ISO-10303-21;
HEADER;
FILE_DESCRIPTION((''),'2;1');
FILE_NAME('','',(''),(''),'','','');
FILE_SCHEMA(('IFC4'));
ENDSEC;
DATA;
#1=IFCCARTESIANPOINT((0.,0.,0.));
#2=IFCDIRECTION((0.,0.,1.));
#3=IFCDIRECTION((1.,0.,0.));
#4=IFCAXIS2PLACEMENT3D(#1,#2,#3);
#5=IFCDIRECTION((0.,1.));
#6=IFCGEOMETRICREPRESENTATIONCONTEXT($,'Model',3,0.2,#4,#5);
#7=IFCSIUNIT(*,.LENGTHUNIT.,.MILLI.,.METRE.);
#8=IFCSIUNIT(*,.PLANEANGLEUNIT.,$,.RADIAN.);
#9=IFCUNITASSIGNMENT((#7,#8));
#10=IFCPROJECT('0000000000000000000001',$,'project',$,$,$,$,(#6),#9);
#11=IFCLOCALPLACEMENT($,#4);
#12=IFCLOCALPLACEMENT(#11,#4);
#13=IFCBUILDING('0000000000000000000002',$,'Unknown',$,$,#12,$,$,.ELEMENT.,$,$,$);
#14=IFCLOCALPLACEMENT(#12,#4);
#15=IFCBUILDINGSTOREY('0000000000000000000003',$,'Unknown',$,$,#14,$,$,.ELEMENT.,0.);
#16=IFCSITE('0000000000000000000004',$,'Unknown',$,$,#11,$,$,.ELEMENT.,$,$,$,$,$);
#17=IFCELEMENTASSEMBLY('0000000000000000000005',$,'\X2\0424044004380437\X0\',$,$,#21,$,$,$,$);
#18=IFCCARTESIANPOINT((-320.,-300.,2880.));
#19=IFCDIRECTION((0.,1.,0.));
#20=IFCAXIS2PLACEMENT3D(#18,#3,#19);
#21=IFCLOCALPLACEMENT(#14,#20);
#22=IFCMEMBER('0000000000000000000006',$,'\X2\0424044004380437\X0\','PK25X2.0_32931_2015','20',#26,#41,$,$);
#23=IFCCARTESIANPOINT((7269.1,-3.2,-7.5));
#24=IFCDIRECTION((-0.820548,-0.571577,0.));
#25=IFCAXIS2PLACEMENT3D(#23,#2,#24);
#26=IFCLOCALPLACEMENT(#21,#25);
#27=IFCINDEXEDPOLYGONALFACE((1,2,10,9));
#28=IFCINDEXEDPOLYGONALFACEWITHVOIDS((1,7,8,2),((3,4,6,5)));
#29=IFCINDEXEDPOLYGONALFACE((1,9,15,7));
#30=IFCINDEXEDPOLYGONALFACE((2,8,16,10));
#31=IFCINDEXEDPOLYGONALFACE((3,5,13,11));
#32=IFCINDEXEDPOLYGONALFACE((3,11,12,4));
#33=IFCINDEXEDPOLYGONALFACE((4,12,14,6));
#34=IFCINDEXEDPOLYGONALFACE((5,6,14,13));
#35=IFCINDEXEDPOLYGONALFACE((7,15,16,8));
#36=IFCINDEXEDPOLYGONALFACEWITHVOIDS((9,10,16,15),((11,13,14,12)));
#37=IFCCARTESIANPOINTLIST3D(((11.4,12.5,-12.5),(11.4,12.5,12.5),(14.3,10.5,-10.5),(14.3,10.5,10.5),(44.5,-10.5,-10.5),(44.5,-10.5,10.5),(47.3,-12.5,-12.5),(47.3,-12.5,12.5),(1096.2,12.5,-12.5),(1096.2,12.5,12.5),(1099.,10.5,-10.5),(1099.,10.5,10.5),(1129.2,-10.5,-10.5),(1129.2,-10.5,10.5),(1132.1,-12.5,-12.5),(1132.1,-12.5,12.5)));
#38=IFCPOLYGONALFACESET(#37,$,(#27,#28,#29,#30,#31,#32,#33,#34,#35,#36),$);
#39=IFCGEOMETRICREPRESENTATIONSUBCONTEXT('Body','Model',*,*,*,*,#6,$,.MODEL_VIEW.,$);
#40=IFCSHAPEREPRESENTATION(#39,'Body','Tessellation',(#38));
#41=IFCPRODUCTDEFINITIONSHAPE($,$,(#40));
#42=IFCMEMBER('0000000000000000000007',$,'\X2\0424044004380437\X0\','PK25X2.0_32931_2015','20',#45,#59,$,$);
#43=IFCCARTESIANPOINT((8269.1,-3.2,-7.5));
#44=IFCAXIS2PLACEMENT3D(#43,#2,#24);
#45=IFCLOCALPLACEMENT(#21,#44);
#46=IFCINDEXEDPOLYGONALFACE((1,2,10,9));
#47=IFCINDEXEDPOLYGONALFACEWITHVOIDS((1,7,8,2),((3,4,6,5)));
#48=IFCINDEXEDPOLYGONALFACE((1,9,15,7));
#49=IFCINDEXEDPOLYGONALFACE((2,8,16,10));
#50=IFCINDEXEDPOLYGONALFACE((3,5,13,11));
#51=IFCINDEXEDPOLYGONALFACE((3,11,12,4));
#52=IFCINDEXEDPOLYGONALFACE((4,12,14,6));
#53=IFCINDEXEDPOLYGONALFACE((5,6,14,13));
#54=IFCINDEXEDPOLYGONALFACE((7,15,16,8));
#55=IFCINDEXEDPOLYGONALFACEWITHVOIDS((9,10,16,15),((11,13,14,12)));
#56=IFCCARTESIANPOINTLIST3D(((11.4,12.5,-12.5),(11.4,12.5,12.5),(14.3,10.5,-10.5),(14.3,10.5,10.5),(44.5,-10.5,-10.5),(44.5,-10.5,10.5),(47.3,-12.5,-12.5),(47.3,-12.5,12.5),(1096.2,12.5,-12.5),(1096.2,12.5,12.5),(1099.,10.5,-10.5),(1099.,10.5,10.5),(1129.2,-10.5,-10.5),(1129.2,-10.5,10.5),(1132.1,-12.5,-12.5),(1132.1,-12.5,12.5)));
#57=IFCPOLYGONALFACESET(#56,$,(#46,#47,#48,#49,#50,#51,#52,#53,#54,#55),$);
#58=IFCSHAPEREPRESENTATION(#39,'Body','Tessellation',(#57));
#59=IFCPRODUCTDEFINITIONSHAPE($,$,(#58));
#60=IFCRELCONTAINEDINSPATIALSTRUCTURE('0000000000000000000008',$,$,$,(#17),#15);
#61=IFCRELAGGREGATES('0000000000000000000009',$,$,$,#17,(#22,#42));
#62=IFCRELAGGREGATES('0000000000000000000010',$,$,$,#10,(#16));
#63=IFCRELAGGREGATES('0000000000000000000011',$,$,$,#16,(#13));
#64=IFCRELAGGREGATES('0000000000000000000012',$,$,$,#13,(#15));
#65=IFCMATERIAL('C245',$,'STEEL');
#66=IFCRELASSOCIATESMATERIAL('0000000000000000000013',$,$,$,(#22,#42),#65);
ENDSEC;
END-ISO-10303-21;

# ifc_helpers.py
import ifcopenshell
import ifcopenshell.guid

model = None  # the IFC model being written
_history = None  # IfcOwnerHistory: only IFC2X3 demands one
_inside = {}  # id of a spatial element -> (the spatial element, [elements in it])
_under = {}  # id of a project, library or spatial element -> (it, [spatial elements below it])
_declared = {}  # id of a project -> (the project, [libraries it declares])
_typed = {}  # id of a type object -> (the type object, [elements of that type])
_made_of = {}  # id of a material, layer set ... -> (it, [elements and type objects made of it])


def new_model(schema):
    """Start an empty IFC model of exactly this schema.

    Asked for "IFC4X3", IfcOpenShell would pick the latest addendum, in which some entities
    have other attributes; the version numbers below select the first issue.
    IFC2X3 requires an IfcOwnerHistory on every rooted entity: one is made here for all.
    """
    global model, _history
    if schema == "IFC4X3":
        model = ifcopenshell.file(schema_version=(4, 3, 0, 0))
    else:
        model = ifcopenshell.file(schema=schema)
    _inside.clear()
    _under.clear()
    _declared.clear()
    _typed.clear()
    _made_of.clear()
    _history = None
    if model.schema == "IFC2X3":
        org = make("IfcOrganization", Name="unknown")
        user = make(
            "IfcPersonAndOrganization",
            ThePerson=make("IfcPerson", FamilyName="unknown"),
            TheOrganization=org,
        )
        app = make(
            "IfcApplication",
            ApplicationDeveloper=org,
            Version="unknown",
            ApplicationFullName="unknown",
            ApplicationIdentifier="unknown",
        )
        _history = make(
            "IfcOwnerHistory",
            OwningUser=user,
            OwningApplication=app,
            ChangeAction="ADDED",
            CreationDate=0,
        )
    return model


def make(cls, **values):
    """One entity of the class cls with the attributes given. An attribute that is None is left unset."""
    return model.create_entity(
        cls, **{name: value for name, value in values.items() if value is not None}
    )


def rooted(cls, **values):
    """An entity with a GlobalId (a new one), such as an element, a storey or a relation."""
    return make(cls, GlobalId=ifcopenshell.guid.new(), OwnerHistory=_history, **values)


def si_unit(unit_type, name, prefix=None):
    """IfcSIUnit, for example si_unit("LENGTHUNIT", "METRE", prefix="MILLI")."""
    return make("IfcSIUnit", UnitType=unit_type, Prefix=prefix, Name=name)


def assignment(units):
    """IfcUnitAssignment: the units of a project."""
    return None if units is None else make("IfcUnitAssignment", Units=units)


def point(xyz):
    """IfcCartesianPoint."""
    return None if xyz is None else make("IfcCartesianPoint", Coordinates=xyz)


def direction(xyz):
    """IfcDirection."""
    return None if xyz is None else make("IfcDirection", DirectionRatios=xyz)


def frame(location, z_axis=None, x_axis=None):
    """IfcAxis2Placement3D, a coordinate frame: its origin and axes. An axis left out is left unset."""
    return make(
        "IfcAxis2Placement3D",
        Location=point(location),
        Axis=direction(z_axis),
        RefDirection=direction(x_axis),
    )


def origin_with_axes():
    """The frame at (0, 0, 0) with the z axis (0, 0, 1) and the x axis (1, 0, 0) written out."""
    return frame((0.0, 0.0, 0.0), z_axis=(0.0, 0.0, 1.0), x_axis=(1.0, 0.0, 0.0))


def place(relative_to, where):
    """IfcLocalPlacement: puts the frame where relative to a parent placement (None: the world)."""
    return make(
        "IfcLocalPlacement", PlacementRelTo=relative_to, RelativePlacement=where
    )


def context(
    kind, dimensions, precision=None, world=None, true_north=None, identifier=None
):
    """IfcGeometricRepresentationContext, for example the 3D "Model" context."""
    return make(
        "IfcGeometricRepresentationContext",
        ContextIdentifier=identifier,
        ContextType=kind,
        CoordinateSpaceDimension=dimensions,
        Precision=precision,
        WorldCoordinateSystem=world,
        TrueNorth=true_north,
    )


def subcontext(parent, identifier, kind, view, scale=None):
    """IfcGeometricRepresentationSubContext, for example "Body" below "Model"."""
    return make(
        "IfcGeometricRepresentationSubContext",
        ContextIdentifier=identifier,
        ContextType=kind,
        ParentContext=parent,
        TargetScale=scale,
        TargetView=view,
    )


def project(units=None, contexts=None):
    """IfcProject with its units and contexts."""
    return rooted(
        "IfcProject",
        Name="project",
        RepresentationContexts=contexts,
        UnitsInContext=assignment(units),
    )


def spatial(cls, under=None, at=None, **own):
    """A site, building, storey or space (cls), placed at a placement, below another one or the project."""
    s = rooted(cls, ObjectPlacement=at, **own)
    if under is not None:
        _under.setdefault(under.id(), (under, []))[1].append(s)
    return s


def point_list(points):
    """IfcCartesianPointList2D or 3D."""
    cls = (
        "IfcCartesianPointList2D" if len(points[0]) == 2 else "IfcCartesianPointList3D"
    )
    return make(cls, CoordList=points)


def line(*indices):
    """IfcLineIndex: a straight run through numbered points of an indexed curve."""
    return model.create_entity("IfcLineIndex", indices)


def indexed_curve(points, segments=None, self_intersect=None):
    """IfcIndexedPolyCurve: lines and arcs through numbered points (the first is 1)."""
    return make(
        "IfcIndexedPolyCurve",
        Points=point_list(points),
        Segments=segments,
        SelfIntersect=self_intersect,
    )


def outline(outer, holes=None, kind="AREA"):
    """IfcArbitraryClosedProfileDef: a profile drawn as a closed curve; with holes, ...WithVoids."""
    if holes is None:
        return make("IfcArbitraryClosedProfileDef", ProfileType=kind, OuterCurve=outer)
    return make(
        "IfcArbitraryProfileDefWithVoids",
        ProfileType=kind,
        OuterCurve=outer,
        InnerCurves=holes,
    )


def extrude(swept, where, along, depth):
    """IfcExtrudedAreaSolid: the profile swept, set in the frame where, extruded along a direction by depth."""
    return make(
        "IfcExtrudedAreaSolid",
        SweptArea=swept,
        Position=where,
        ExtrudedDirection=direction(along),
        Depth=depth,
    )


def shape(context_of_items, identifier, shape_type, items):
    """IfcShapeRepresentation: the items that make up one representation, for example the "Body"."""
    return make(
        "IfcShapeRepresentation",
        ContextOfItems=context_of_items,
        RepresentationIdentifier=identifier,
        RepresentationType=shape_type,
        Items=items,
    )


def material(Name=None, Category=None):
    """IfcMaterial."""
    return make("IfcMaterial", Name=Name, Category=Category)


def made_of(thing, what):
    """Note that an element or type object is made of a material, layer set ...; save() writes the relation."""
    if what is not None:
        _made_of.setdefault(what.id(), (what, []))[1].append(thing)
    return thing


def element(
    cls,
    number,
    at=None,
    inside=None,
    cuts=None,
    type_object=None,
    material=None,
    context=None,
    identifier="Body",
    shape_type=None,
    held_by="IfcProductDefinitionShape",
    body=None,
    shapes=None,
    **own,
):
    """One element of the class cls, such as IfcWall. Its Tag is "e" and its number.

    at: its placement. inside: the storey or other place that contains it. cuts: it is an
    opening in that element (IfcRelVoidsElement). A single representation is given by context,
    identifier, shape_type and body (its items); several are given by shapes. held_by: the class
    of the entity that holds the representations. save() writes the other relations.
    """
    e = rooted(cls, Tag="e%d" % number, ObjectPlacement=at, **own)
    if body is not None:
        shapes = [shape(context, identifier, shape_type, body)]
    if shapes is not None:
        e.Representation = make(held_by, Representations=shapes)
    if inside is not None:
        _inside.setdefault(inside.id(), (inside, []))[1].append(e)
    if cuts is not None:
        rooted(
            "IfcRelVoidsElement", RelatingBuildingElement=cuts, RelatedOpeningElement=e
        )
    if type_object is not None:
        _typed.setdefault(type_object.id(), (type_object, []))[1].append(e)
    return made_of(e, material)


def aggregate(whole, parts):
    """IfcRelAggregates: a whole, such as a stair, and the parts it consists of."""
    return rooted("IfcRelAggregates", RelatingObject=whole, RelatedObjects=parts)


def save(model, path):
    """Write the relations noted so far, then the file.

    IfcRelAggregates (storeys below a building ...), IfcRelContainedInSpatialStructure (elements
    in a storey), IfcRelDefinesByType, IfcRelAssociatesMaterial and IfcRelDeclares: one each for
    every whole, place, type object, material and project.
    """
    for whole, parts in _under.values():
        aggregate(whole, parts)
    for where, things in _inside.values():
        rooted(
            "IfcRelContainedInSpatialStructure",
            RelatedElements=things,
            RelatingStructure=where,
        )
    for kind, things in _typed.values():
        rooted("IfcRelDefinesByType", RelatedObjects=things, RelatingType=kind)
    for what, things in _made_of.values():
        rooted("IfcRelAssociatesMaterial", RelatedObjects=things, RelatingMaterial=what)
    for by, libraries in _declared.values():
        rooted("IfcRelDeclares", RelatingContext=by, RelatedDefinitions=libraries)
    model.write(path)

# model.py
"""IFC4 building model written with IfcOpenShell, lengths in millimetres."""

from ifc_helpers import new_model, si_unit, direction, frame, origin_with_axes, place, context, subcontext, project, spatial, line, indexed_curve, outline, extrude, material, element, aggregate, save


model = new_model("IFC4")

# Units and contexts
model_context = context("Model", 3, precision=0.2, world=origin_with_axes(), true_north=direction((0.0, 1.0)))
body_context = subcontext(model_context, "Body", "Model", "MODEL_VIEW")
ifc_project = project(units=[si_unit("LENGTHUNIT", "METRE", prefix="MILLI"), si_unit("PLANEANGLEUNIT", "RADIAN")], contexts=[model_context])

# Site, building, storey
site_placement = place(None, origin_with_axes())
site = spatial("IfcSite", under=ifc_project, at=site_placement, Name="Unknown", CompositionType="ELEMENT")
building_placement = place(site_placement, origin_with_axes())
building = spatial("IfcBuilding", under=site, at=building_placement, Name="Unknown", CompositionType="ELEMENT")
storey_placement = place(building_placement, origin_with_axes())
storey = spatial("IfcBuildingStorey", under=building, at=storey_placement, Name="Unknown", CompositionType="ELEMENT", Elevation=0.0)

# Shared definitions
ifc_material_1 = material(Name="C245", Category="STEEL")

# Element assembly, members, voiding features
assembly_1_placement = place(storey_placement, frame((-320.0, -300.0, 2880.0), z_axis=(1.0, 0.0, 0.0), x_axis=(0.0, 1.0, 0.0)))
assembly_1 = element("IfcElementAssembly", 1, at=assembly_1_placement, inside=storey, Name="Фриз")
member_1_placement = place(assembly_1_placement, frame((7269.1, -3.2, -7.5), z_axis=(0.0, 0.0, 1.0), x_axis=(-0.820548, -0.571577, 0.0)))
member_1 = element("IfcMember", 2, at=member_1_placement, material=ifc_material_1, Name="Фриз", Description="PK25X2.0_32931_2015", ObjectType="20", context=body_context, shape_type="SolidModel", body=[
    extrude(outline(indexed_curve([(-12.5, -12.5), (12.5, -12.5), (12.5, 12.5), (-12.5, 12.5)], segments=[line(1, 2, 3, 4, 1)]), holes=[indexed_curve([(-10.5, -10.5), (-10.5, 10.5), (10.5, 10.5), (10.5, -10.5)], segments=[line(1, 2, 3, 4, 1)])]), frame((0.0, 0.0, 0.0), z_axis=(-1.0, 0.0, 0.0), x_axis=(0.0, 0.0, 1.0)), (0.0, 0.0, -1.0), 1143.5),
])
voiding_feature_1_placement = place(member_1_placement, frame((899.1, -630.2, 7.5), z_axis=(0.0, 0.0, 1.0), x_axis=(-0.820548, 0.571577, 0.0)))
element("IfcVoidingFeature", 3, at=voiding_feature_1_placement, cuts=member_1, Name="CUT_BEAM", ObjectType="(?)", PredefinedType="HOLE", context=body_context, shape_type="SolidModel", body=[
    extrude(outline(indexed_curve([(-20.0, -20.0), (20.0, -20.0), (20.0, 20.0), (-20.0, 20.0)], segments=[line(1, 2, 3, 4, 1)])), frame((0.0, 0.0, 0.0), z_axis=(-1.0, 0.0, 0.0), x_axis=(0.0, 0.0, 1.0)), (0.0, 0.0, -1.0), 2205.1),
])
voiding_feature_2_placement = place(member_1_placement, frame((2053.8, -630.2, 7.5), z_axis=(0.0, 0.0, 1.0), x_axis=(-0.820548, 0.571577, 0.0)))
element("IfcVoidingFeature", 4, at=voiding_feature_2_placement, cuts=member_1, Name="CUT_BEAM", ObjectType="(?)", PredefinedType="HOLE", context=body_context, shape_type="SolidModel", body=[
    extrude(outline(indexed_curve([(-20.0, -20.0), (20.0, -20.0), (20.0, 20.0), (-20.0, 20.0)], segments=[line(1, 2, 3, 4, 1)])), frame((0.0, 0.0, 0.0), z_axis=(-1.0, 0.0, 0.0), x_axis=(0.0, 0.0, 1.0)), (0.0, 0.0, -1.0), 2205.1),
])
member_2_placement = place(assembly_1_placement, frame((8269.1, -3.2, -7.5), z_axis=(0.0, 0.0, 1.0), x_axis=(-0.820548, -0.571577, 0.0)))
member_2 = element("IfcMember", 5, at=member_2_placement, material=ifc_material_1, Name="Фриз", Description="PK25X2.0_32931_2015", ObjectType="20", context=body_context, shape_type="SolidModel", body=[
    extrude(outline(indexed_curve([(-12.5, -12.5), (12.5, -12.5), (12.5, 12.5), (-12.5, 12.5)], segments=[line(1, 2, 3, 4, 1)]), holes=[indexed_curve([(-10.5, -10.5), (-10.5, 10.5), (10.5, 10.5), (10.5, -10.5)], segments=[line(1, 2, 3, 4, 1)])]), frame((0.0, 0.0, 0.0), z_axis=(-1.0, 0.0, 0.0), x_axis=(0.0, 0.0, 1.0)), (0.0, 0.0, -1.0), 1143.5),
])
voiding_feature_3_placement = place(member_2_placement, frame((899.1, -630.2, 7.5), z_axis=(0.0, 0.0, 1.0), x_axis=(-0.820548, 0.571577, 0.0)))
element("IfcVoidingFeature", 6, at=voiding_feature_3_placement, cuts=member_2, Name="CUT_BEAM", ObjectType="(?)", PredefinedType="HOLE", context=body_context, shape_type="SolidModel", body=[
    extrude(outline(indexed_curve([(-20.0, -20.0), (20.0, -20.0), (20.0, 20.0), (-20.0, 20.0)], segments=[line(1, 2, 3, 4, 1)])), frame((0.0, 0.0, 0.0), z_axis=(-1.0, 0.0, 0.0), x_axis=(0.0, 0.0, 1.0)), (0.0, 0.0, -1.0), 2205.1),
])
voiding_feature_4_placement = place(member_2_placement, frame((2053.8, -630.2, 7.5), z_axis=(0.0, 0.0, 1.0), x_axis=(-0.820548, 0.571577, 0.0)))
element("IfcVoidingFeature", 7, at=voiding_feature_4_placement, cuts=member_2, Name="CUT_BEAM", ObjectType="(?)", PredefinedType="HOLE", context=body_context, shape_type="SolidModel", body=[
    extrude(outline(indexed_curve([(-20.0, -20.0), (20.0, -20.0), (20.0, 20.0), (-20.0, 20.0)], segments=[line(1, 2, 3, 4, 1)])), frame((0.0, 0.0, 0.0), z_axis=(-1.0, 0.0, 0.0), x_axis=(0.0, 0.0, 1.0)), (0.0, 0.0, -1.0), 2205.1),
])
aggregate(assembly_1, [member_1, member_2])

save(model, "model.ifc")
